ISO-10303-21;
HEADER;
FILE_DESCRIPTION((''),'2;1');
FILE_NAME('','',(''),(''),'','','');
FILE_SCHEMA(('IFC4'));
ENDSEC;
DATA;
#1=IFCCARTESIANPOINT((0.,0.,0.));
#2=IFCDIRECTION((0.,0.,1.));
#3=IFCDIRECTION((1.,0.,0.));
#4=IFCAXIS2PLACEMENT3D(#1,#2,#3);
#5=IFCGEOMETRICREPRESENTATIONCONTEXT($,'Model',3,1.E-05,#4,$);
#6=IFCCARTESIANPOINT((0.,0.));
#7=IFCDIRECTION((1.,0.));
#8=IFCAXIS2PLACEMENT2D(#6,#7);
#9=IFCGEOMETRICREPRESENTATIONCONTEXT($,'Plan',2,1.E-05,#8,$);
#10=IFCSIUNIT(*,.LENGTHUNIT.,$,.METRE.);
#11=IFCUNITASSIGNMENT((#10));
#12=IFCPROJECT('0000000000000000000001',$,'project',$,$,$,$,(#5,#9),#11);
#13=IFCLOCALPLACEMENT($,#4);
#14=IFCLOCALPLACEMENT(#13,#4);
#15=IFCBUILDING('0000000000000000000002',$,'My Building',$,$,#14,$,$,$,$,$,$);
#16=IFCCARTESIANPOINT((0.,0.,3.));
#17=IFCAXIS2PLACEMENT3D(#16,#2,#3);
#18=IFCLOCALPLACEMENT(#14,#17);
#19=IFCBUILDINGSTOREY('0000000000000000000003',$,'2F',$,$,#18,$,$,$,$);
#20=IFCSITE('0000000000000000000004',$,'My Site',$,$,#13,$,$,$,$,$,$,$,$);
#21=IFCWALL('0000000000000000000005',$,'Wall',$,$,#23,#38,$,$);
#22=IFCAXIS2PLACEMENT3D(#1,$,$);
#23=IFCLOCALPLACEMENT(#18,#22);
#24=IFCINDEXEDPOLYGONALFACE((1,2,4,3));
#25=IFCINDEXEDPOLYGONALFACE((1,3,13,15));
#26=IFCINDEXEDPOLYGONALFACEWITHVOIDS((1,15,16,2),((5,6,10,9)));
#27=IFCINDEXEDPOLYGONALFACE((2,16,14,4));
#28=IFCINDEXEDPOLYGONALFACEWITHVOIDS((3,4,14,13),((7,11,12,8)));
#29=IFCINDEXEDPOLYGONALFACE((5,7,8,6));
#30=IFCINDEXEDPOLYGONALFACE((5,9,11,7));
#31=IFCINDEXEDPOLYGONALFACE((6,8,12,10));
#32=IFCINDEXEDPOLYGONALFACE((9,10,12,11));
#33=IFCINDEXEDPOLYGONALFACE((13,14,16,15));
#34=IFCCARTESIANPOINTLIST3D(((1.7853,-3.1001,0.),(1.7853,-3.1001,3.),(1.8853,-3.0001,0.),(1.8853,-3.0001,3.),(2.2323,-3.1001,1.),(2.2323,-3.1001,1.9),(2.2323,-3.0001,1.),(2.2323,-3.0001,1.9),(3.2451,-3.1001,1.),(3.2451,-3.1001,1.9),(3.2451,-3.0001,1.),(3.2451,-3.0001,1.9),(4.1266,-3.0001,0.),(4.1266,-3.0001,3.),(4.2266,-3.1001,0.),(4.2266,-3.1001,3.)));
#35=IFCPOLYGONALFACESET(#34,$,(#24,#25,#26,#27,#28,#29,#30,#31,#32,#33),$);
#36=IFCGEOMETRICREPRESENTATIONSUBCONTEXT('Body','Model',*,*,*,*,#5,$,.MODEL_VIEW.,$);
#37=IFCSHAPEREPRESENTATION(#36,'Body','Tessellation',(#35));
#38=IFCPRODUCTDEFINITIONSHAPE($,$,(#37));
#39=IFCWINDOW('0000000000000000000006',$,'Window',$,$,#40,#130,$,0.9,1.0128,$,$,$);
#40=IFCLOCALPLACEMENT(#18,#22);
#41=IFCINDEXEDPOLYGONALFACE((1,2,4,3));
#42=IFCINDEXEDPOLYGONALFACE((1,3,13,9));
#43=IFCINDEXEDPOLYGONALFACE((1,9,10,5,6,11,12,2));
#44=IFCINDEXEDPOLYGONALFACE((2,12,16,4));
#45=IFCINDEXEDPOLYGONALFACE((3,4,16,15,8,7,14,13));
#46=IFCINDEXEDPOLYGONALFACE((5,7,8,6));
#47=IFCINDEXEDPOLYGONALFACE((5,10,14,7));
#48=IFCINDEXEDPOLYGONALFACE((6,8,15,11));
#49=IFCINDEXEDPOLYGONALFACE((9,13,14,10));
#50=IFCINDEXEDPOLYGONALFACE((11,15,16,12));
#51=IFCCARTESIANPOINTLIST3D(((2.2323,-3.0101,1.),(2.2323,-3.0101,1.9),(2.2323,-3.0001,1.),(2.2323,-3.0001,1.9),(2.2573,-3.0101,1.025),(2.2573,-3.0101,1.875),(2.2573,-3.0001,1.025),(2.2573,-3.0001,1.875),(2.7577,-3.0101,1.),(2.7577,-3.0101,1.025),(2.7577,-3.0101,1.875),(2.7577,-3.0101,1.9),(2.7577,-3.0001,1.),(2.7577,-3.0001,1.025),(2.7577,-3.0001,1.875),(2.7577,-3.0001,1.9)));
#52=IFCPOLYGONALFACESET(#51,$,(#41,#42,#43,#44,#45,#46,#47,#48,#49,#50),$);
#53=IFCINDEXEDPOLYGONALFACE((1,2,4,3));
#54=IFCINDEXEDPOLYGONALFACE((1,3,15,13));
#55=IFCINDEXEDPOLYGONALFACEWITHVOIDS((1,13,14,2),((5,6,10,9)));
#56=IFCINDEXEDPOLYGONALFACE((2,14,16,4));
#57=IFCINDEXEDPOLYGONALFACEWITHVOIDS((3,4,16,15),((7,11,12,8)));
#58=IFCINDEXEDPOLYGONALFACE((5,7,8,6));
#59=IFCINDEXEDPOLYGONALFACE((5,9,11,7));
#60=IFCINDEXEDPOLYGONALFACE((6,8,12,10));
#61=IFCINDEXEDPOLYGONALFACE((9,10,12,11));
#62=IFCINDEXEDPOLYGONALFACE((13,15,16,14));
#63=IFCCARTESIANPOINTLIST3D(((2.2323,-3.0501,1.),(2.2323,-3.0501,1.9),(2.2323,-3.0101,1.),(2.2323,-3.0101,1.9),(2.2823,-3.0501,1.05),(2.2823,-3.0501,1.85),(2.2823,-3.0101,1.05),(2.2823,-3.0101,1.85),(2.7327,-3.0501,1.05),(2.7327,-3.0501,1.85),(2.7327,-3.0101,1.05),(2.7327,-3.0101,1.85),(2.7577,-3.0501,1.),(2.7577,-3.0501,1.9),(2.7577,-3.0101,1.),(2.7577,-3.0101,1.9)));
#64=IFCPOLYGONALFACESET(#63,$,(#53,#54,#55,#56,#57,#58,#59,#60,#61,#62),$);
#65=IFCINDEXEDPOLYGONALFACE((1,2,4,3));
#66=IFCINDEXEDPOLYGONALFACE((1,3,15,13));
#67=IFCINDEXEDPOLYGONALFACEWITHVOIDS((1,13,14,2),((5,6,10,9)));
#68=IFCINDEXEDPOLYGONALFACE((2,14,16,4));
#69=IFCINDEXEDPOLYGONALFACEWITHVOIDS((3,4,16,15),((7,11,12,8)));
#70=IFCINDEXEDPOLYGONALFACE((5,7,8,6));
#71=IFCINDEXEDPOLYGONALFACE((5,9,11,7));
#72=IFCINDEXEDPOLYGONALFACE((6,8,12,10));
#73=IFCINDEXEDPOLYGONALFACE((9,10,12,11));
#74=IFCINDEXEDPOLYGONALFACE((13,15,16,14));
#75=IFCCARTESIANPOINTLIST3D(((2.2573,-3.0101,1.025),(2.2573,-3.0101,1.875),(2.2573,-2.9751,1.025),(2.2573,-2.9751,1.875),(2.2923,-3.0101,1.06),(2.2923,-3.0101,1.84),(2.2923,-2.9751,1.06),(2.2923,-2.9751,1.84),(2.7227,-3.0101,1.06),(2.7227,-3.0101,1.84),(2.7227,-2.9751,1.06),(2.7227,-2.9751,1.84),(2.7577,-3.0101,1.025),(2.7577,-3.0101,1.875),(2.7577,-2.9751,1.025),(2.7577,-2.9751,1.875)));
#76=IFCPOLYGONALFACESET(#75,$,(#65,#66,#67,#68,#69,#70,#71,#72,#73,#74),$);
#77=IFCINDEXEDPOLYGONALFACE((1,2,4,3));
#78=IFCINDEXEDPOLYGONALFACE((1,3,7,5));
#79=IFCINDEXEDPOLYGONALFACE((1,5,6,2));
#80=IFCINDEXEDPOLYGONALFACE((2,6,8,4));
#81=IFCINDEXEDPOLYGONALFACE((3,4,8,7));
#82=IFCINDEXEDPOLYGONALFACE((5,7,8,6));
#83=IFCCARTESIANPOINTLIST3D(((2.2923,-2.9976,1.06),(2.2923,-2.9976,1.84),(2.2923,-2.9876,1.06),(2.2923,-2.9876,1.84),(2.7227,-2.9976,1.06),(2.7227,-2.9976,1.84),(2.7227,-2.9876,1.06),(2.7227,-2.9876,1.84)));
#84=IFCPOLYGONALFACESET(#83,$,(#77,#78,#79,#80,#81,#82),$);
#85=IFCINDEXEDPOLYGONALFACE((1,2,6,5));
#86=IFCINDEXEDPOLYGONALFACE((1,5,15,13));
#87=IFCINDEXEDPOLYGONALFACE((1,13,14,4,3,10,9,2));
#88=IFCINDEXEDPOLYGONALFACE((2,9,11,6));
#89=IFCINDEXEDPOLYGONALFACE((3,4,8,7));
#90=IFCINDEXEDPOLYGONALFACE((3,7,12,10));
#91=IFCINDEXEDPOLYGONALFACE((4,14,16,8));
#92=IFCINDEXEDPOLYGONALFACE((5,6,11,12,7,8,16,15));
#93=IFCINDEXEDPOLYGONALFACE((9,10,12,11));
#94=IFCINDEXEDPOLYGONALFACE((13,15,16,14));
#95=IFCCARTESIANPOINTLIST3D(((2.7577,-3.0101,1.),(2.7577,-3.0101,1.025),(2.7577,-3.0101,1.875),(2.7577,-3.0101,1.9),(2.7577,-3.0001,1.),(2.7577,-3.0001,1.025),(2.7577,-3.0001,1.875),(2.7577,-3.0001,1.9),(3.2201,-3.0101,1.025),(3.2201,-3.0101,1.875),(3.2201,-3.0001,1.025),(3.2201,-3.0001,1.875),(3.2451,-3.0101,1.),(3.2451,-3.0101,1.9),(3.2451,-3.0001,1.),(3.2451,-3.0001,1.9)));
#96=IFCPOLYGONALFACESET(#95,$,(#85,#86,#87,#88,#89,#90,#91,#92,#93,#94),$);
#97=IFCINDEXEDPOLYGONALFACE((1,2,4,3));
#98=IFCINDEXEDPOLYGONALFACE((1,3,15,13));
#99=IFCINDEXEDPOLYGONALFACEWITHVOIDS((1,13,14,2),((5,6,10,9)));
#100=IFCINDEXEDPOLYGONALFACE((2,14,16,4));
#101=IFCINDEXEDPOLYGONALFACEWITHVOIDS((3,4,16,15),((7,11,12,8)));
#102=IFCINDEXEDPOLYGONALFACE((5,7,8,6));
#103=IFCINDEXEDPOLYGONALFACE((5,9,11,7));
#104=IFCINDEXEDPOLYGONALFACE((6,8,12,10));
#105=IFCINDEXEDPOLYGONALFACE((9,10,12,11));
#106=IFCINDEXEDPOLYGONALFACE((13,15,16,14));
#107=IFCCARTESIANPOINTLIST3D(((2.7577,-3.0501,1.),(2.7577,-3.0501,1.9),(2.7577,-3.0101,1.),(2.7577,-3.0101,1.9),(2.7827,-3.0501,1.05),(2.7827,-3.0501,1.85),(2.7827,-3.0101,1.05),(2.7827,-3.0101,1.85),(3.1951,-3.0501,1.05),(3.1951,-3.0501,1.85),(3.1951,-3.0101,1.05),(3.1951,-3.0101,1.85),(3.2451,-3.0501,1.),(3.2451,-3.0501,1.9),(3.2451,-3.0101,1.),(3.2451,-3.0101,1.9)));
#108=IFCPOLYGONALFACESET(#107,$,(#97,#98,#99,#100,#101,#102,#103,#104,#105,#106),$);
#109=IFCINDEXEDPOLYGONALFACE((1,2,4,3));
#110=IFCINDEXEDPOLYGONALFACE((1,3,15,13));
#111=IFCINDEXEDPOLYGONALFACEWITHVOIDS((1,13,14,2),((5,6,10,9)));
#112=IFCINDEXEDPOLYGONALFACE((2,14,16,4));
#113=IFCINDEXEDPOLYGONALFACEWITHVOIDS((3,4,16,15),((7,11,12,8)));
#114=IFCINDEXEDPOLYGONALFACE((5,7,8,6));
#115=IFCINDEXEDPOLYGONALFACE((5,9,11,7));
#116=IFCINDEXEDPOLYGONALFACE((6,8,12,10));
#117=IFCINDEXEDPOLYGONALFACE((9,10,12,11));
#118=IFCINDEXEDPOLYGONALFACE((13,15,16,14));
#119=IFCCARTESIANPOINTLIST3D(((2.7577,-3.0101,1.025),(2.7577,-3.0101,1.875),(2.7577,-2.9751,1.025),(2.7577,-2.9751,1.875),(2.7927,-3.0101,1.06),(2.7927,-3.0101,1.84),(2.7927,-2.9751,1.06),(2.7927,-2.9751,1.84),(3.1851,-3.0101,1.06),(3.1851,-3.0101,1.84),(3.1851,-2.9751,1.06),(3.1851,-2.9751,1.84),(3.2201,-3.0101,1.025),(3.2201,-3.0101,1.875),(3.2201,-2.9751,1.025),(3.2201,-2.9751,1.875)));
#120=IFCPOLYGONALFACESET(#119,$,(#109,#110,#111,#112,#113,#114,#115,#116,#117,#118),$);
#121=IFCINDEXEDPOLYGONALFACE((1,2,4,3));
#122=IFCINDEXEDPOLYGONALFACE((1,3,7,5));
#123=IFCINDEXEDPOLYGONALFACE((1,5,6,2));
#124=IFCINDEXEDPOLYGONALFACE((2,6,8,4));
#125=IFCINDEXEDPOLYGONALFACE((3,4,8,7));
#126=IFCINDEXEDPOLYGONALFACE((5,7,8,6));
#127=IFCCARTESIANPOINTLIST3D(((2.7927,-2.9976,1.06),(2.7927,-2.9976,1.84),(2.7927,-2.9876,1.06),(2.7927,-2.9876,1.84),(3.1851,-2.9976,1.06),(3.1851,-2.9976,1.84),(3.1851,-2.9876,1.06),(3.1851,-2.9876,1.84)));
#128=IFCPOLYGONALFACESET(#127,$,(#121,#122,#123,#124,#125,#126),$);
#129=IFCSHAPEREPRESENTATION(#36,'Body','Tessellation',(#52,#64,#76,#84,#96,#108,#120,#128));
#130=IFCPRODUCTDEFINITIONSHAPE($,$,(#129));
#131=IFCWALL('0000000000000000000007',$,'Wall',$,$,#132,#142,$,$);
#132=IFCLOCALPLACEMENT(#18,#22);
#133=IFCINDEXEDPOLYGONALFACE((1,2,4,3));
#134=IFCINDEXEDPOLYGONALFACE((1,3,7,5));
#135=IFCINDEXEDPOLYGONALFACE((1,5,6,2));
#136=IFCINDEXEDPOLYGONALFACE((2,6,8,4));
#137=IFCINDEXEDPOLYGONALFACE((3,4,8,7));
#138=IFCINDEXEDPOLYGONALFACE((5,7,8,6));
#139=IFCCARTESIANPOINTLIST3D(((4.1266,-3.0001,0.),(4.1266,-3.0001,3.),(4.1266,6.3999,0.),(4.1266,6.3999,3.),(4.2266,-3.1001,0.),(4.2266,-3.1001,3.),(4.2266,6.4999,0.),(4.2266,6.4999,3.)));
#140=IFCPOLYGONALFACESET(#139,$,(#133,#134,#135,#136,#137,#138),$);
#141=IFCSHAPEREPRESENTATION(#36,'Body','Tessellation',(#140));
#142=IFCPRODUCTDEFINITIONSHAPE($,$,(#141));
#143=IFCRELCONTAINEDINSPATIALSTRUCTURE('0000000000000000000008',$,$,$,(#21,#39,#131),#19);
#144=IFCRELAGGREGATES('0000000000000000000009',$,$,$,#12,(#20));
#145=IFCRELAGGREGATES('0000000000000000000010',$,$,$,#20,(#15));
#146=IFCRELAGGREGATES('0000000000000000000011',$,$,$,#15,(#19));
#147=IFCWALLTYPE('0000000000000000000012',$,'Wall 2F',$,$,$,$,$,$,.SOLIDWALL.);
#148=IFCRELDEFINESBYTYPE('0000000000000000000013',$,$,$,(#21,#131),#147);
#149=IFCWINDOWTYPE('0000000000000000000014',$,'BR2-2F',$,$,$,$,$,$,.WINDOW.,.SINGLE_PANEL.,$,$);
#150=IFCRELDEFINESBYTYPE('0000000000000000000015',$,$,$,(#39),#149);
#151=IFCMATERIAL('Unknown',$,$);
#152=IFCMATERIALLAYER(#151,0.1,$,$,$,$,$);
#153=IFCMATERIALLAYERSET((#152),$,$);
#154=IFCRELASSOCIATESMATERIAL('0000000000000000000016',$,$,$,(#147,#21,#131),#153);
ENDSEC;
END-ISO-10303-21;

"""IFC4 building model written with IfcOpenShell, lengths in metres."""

from ifc_helpers import new_model, entity, si_unit, frame, origin_with_axes, origin_2d_with_axis, place, context, subcontext, project, spatial, line, indexed_curve, outline, extrude, shape, source, transform, mapped, material, layer, layer_set, layer_usage, type_object, type_shapes, element, fill, save


model = new_model("IFC4")

# Units and contexts
model_context = context("Model", 3, precision=1e-05, world=origin_with_axes())
plan_context = context("Plan", 2, precision=1e-05, world=origin_2d_with_axis())
body_context_1 = subcontext(model_context, "Body", "Model", "MODEL_VIEW")
body_context_2 = subcontext(plan_context, "Body", "Plan", "PLAN_VIEW")
ifc_project = project(units=[si_unit("LENGTHUNIT", "METRE")], contexts=[model_context, plan_context])

# Site, building, storey
site_placement = place(None, origin_with_axes())
site = spatial("IfcSite", under=ifc_project, at=site_placement, Name="My Site")
building_placement = place(site_placement, origin_with_axes())
building = spatial("IfcBuilding", under=site, at=building_placement, Name="My Building")
storey_placement = place(building_placement, frame((0.0, 0.0, 3.0), z_axis=(0.0, 0.0, 1.0), x_axis=(1.0, 0.0, 0.0)))
storey = spatial("IfcBuildingStorey", under=building, at=storey_placement, Name="2F")

# Shared definitions
ifc_material = material(Name="Unknown")

# Wall, opening, window
ifc_layer_1 = layer(ifc_material, 0.1)
ifc_layer_set_1 = layer_set([ifc_layer_1])
ifc_layer_usage_1 = layer_usage(ifc_layer_set_1, "AXIS2", "POSITIVE", 0.0)
wall_type = type_object("IfcWallType", Name="Wall 2F", PredefinedType="SOLIDWALL", material=ifc_layer_set_1)
wall_1_placement = place(storey_placement, frame((1.7853, -3.1001, 0.0), z_axis=(0.0, 0.0, 1.0), x_axis=(1.0, 0.0, 0.0)))
wall_1 = element("IfcWall", 1, at=wall_1_placement, inside=storey, type_object=wall_type, material=ifc_layer_usage_1, Name="Wall", context=body_context_1, shape_type="SweptSolid", body=[
    extrude(outline(indexed_curve([(0.0, 0.0), (0.1, 0.1), (2.3413, 0.1), (2.4413, 0.0)], segments=[line(1, 2, 3, 4, 1)])), origin_with_axes(), (0.0, 0.0, 1.0), 3.0),
])
shared_shape_1 = source(origin_with_axes(), body_context_1, "Body", "SweptSolid", [
    extrude(outline(indexed_curve([(0.0, 0.0), (1.0128, 0.0), (1.0128, 0.9), (0.0, 0.9)], segments=[line(1, 2, 3, 4, 1)])), frame((0.0, -0.6, 0.0), z_axis=(0.0, -1.0, 0.0), x_axis=(1.0, 0.0, 0.0)), (0.0, 0.0, -1.0), 1.2),
])
opening_1_placement = place(wall_1_placement, frame((0.4471, 0.0, 1.0), z_axis=(0.0, 0.0, 1.0), x_axis=(1.0, 0.0, 0.0)))
opening_1 = element("IfcOpeningElement", 2, at=opening_1_placement, cuts=wall_1, PredefinedType="OPENING", context=body_context_1, shape_type="MappedRepresentation", body=[
    mapped(shared_shape_1, transform((0.0, 0.0, 0.0), x_axis=(1.0, 0.0, 0.0), y_axis=(0.0, 1.0, 0.0), z_axis=(0.0, 0.0, 1.0), scale=1.0)),
])
window_type = type_object("IfcWindowType", Name="BR2-2F", PartitioningType="SINGLE_PANEL", PredefinedType="WINDOW")
shared_shape_2 = source(origin_with_axes(), body_context_1, "Body", "SweptSolid", [
    extrude(outline(indexed_curve([(0.5254, 0.0), (0.0, 0.0), (0.0, 0.9), (0.5254, 0.9), (0.5254, 0.875), (0.025, 0.875), (0.025, 0.025), (0.5254, 0.025)], segments=[line(1, 2, 3, 4, 5, 6, 7, 8, 1)])), frame((0.0, 0.09, 0.0), z_axis=(0.0, -1.0, 0.0), x_axis=(1.0, 0.0, 0.0)), (0.0, 0.0, -1.0), 0.01),
    extrude(outline(indexed_curve([(0.0, 0.0), (0.5254, 0.0), (0.5254, 0.9), (0.0, 0.9)], segments=[line(1, 2, 3, 4, 1)]), holes=[indexed_curve([(0.05, 0.05), (0.5004, 0.05), (0.5004, 0.85), (0.05, 0.85)], segments=[line(1, 2, 3, 4, 1)])]), frame((0.0, 0.05, 0.0), z_axis=(0.0, -1.0, 0.0), x_axis=(1.0, 0.0, 0.0)), (0.0, 0.0, -1.0), 0.04),
    extrude(outline(indexed_curve([(0.0, 0.0), (0.5004, 0.0), (0.5004, 0.85), (0.0, 0.85)], segments=[line(1, 2, 3, 4, 1)]), holes=[indexed_curve([(0.035, 0.035), (0.4654, 0.035), (0.4654, 0.815), (0.035, 0.815)], segments=[line(1, 2, 3, 4, 1)])]), frame((0.025, 0.09, 0.025), z_axis=(0.0, -1.0, 0.0), x_axis=(1.0, 0.0, 0.0)), (0.0, 0.0, -1.0), 0.035),
    extrude(outline(indexed_curve([(0.035, 0.035), (0.4654, 0.035), (0.4654, 0.815), (0.035, 0.815)], segments=[line(1, 2, 3, 4, 1)])), frame((0.025, 0.1025, 0.025), z_axis=(0.0, -1.0, 0.0), x_axis=(1.0, 0.0, 0.0)), (0.0, 0.0, -1.0), 0.01),
    extrude(outline(indexed_curve([(0.0, 0.9), (0.4875, 0.9), (0.4875, 0.0), (0.0, 0.0), (0.0, 0.025), (0.4625, 0.025), (0.4625, 0.875), (0.0, 0.875)], segments=[line(1, 2, 3, 4, 5, 6, 7, 8, 1)])), frame((0.5254, 0.09, 0.0), z_axis=(0.0, -1.0, 0.0), x_axis=(1.0, 0.0, 0.0)), (0.0, 0.0, -1.0), 0.01),
    extrude(outline(indexed_curve([(0.0, 0.0), (0.4875, 0.0), (0.4875, 0.9), (0.0, 0.9)], segments=[line(1, 2, 3, 4, 1)]), holes=[indexed_curve([(0.025, 0.05), (0.4375, 0.05), (0.4375, 0.85), (0.025, 0.85)], segments=[line(1, 2, 3, 4, 1)])]), frame((0.5254, 0.05, 0.0), z_axis=(0.0, -1.0, 0.0), x_axis=(1.0, 0.0, 0.0)), (0.0, 0.0, -1.0), 0.04),
    extrude(outline(indexed_curve([(0.0, 0.0), (0.4625, 0.0), (0.4625, 0.85), (0.0, 0.85)], segments=[line(1, 2, 3, 4, 1)]), holes=[indexed_curve([(0.035, 0.035), (0.4275, 0.035), (0.4275, 0.815), (0.035, 0.815)], segments=[line(1, 2, 3, 4, 1)])]), frame((0.5254, 0.09, 0.025), z_axis=(0.0, -1.0, 0.0), x_axis=(1.0, 0.0, 0.0)), (0.0, 0.0, -1.0), 0.035),
    extrude(outline(indexed_curve([(0.035, 0.035), (0.4275, 0.035), (0.4275, 0.815), (0.035, 0.815)], segments=[line(1, 2, 3, 4, 1)])), frame((0.5254, 0.1025, 0.025), z_axis=(0.0, -1.0, 0.0), x_axis=(1.0, 0.0, 0.0)), (0.0, 0.0, -1.0), 0.01),
])
shared_shape_3 = source(origin_with_axes(), body_context_2, "Body", "Curve2D", [
    entity("IfcIndexedPolyCurve", entity("IfcCartesianPointList2D", [[0.05, 0.05], [0.5004, 0.05]])),
    entity("IfcIndexedPolyCurve", entity("IfcCartesianPointList2D", [[0.0, 0.1], [0.025, 0.1], [0.025, 0.09], [0.05, 0.09], [0.05, 0.05], [0.0, 0.05]]), [entity("IfcLineIndex", [1, 2, 3, 4, 5, 6, 1])]),
    entity("IfcIndexedPolyCurve", entity("IfcCartesianPointList2D", [[0.5254, 0.1], [0.5254, 0.1], [0.5254, 0.09], [0.5004, 0.09], [0.5004, 0.05], [0.5254, 0.05]])),
    entity("IfcIndexedPolyCurve", entity("IfcCartesianPointList2D", [[0.025, 0.09], [0.06, 0.09], [0.06, 0.125], [0.025, 0.125]]), [entity("IfcLineIndex", [1, 2, 3, 4, 1])]),
    entity("IfcIndexedPolyCurve", entity("IfcCartesianPointList2D", [[0.5254, 0.09], [0.4904, 0.09], [0.4904, 0.125], [0.5254, 0.125]]), [entity("IfcLineIndex", [1, 2, 3, 4, 1])]),
    entity("IfcIndexedPolyCurve", entity("IfcCartesianPointList2D", [[0.06, 0.09], [0.4904, 0.09]])),
    entity("IfcIndexedPolyCurve", entity("IfcCartesianPointList2D", [[0.06, 0.125], [0.4904, 0.125]])),
    entity("IfcIndexedPolyCurve", entity("IfcCartesianPointList2D", [[0.06, 0.1075], [0.4904, 0.1075]])),
    entity("IfcIndexedPolyCurve", entity("IfcCartesianPointList2D", [[0.5504, 0.05], [0.9628, 0.05]])),
    entity("IfcIndexedPolyCurve", entity("IfcCartesianPointList2D", [[0.5254, 0.1], [0.5254, 0.1], [0.5254, 0.09], [0.5504, 0.09], [0.5504, 0.05], [0.5254, 0.05]])),
    entity("IfcIndexedPolyCurve", entity("IfcCartesianPointList2D", [[1.0128, 0.1], [0.9878, 0.1], [0.9878, 0.09], [0.9628, 0.09], [0.9628, 0.05], [1.0128, 0.05]]), [entity("IfcLineIndex", [1, 2, 3, 4, 5, 6, 1])]),
    entity("IfcIndexedPolyCurve", entity("IfcCartesianPointList2D", [[0.5254, 0.09], [0.5604, 0.09], [0.5604, 0.125], [0.5254, 0.125]]), [entity("IfcLineIndex", [1, 2, 3, 4, 1])]),
    entity("IfcIndexedPolyCurve", entity("IfcCartesianPointList2D", [[0.9878, 0.09], [0.9528, 0.09], [0.9528, 0.125], [0.9878, 0.125]]), [entity("IfcLineIndex", [1, 2, 3, 4, 1])]),
    entity("IfcIndexedPolyCurve", entity("IfcCartesianPointList2D", [[0.5604, 0.09], [0.9528, 0.09]])),
    entity("IfcIndexedPolyCurve", entity("IfcCartesianPointList2D", [[0.5604, 0.125], [0.9528, 0.125]])),
    entity("IfcIndexedPolyCurve", entity("IfcCartesianPointList2D", [[0.5604, 0.1075], [0.9528, 0.1075]])),
])
type_shapes(window_type, [shared_shape_2, shared_shape_3])
window_placement = place(opening_1_placement, origin_with_axes())
window = element("IfcWindow", 3, at=window_placement, inside=storey, type_object=window_type, Name="Window", OverallHeight=0.9, OverallWidth=1.0128, shapes=[
    shape(body_context_1, "Body", "MappedRepresentation", [mapped(shared_shape_2, transform((0.0, 0.0, 0.0), x_axis=(1.0, 0.0, 0.0), y_axis=(0.0, 1.0, 0.0), z_axis=(0.0, 0.0, 1.0), scale=1.0))]),
    shape(body_context_2, "Body", "MappedRepresentation", [mapped(shared_shape_3, transform((0.0, 0.0, 0.0), x_axis=(1.0, 0.0, 0.0), y_axis=(0.0, 1.0, 0.0), z_axis=(0.0, 0.0, 1.0), scale=1.0))]),
])
fill(opening_1, window)

# Wall
ifc_layer_usage_2 = layer_usage(ifc_layer_set_1, "AXIS2", "POSITIVE", 0.0)
wall_2_placement = place(storey_placement, frame((4.2266, -3.1001, 0.0), z_axis=(0.0, 0.0, 1.0), x_axis=(0.0, 1.0, 0.0)))
element("IfcWall", 4, at=wall_2_placement, inside=storey, type_object=wall_type, material=ifc_layer_usage_2, Name="Wall", context=body_context_1, shape_type="SweptSolid", body=[
    extrude(outline(indexed_curve([(0.0, 0.0), (0.1, 0.1), (9.5, 0.1), (9.6, 0.0)], segments=[line(1, 2, 3, 4, 1)])), origin_with_axes(), (0.0, 0.0, 1.0), 3.0),
])

save(model, "model.ifc")
